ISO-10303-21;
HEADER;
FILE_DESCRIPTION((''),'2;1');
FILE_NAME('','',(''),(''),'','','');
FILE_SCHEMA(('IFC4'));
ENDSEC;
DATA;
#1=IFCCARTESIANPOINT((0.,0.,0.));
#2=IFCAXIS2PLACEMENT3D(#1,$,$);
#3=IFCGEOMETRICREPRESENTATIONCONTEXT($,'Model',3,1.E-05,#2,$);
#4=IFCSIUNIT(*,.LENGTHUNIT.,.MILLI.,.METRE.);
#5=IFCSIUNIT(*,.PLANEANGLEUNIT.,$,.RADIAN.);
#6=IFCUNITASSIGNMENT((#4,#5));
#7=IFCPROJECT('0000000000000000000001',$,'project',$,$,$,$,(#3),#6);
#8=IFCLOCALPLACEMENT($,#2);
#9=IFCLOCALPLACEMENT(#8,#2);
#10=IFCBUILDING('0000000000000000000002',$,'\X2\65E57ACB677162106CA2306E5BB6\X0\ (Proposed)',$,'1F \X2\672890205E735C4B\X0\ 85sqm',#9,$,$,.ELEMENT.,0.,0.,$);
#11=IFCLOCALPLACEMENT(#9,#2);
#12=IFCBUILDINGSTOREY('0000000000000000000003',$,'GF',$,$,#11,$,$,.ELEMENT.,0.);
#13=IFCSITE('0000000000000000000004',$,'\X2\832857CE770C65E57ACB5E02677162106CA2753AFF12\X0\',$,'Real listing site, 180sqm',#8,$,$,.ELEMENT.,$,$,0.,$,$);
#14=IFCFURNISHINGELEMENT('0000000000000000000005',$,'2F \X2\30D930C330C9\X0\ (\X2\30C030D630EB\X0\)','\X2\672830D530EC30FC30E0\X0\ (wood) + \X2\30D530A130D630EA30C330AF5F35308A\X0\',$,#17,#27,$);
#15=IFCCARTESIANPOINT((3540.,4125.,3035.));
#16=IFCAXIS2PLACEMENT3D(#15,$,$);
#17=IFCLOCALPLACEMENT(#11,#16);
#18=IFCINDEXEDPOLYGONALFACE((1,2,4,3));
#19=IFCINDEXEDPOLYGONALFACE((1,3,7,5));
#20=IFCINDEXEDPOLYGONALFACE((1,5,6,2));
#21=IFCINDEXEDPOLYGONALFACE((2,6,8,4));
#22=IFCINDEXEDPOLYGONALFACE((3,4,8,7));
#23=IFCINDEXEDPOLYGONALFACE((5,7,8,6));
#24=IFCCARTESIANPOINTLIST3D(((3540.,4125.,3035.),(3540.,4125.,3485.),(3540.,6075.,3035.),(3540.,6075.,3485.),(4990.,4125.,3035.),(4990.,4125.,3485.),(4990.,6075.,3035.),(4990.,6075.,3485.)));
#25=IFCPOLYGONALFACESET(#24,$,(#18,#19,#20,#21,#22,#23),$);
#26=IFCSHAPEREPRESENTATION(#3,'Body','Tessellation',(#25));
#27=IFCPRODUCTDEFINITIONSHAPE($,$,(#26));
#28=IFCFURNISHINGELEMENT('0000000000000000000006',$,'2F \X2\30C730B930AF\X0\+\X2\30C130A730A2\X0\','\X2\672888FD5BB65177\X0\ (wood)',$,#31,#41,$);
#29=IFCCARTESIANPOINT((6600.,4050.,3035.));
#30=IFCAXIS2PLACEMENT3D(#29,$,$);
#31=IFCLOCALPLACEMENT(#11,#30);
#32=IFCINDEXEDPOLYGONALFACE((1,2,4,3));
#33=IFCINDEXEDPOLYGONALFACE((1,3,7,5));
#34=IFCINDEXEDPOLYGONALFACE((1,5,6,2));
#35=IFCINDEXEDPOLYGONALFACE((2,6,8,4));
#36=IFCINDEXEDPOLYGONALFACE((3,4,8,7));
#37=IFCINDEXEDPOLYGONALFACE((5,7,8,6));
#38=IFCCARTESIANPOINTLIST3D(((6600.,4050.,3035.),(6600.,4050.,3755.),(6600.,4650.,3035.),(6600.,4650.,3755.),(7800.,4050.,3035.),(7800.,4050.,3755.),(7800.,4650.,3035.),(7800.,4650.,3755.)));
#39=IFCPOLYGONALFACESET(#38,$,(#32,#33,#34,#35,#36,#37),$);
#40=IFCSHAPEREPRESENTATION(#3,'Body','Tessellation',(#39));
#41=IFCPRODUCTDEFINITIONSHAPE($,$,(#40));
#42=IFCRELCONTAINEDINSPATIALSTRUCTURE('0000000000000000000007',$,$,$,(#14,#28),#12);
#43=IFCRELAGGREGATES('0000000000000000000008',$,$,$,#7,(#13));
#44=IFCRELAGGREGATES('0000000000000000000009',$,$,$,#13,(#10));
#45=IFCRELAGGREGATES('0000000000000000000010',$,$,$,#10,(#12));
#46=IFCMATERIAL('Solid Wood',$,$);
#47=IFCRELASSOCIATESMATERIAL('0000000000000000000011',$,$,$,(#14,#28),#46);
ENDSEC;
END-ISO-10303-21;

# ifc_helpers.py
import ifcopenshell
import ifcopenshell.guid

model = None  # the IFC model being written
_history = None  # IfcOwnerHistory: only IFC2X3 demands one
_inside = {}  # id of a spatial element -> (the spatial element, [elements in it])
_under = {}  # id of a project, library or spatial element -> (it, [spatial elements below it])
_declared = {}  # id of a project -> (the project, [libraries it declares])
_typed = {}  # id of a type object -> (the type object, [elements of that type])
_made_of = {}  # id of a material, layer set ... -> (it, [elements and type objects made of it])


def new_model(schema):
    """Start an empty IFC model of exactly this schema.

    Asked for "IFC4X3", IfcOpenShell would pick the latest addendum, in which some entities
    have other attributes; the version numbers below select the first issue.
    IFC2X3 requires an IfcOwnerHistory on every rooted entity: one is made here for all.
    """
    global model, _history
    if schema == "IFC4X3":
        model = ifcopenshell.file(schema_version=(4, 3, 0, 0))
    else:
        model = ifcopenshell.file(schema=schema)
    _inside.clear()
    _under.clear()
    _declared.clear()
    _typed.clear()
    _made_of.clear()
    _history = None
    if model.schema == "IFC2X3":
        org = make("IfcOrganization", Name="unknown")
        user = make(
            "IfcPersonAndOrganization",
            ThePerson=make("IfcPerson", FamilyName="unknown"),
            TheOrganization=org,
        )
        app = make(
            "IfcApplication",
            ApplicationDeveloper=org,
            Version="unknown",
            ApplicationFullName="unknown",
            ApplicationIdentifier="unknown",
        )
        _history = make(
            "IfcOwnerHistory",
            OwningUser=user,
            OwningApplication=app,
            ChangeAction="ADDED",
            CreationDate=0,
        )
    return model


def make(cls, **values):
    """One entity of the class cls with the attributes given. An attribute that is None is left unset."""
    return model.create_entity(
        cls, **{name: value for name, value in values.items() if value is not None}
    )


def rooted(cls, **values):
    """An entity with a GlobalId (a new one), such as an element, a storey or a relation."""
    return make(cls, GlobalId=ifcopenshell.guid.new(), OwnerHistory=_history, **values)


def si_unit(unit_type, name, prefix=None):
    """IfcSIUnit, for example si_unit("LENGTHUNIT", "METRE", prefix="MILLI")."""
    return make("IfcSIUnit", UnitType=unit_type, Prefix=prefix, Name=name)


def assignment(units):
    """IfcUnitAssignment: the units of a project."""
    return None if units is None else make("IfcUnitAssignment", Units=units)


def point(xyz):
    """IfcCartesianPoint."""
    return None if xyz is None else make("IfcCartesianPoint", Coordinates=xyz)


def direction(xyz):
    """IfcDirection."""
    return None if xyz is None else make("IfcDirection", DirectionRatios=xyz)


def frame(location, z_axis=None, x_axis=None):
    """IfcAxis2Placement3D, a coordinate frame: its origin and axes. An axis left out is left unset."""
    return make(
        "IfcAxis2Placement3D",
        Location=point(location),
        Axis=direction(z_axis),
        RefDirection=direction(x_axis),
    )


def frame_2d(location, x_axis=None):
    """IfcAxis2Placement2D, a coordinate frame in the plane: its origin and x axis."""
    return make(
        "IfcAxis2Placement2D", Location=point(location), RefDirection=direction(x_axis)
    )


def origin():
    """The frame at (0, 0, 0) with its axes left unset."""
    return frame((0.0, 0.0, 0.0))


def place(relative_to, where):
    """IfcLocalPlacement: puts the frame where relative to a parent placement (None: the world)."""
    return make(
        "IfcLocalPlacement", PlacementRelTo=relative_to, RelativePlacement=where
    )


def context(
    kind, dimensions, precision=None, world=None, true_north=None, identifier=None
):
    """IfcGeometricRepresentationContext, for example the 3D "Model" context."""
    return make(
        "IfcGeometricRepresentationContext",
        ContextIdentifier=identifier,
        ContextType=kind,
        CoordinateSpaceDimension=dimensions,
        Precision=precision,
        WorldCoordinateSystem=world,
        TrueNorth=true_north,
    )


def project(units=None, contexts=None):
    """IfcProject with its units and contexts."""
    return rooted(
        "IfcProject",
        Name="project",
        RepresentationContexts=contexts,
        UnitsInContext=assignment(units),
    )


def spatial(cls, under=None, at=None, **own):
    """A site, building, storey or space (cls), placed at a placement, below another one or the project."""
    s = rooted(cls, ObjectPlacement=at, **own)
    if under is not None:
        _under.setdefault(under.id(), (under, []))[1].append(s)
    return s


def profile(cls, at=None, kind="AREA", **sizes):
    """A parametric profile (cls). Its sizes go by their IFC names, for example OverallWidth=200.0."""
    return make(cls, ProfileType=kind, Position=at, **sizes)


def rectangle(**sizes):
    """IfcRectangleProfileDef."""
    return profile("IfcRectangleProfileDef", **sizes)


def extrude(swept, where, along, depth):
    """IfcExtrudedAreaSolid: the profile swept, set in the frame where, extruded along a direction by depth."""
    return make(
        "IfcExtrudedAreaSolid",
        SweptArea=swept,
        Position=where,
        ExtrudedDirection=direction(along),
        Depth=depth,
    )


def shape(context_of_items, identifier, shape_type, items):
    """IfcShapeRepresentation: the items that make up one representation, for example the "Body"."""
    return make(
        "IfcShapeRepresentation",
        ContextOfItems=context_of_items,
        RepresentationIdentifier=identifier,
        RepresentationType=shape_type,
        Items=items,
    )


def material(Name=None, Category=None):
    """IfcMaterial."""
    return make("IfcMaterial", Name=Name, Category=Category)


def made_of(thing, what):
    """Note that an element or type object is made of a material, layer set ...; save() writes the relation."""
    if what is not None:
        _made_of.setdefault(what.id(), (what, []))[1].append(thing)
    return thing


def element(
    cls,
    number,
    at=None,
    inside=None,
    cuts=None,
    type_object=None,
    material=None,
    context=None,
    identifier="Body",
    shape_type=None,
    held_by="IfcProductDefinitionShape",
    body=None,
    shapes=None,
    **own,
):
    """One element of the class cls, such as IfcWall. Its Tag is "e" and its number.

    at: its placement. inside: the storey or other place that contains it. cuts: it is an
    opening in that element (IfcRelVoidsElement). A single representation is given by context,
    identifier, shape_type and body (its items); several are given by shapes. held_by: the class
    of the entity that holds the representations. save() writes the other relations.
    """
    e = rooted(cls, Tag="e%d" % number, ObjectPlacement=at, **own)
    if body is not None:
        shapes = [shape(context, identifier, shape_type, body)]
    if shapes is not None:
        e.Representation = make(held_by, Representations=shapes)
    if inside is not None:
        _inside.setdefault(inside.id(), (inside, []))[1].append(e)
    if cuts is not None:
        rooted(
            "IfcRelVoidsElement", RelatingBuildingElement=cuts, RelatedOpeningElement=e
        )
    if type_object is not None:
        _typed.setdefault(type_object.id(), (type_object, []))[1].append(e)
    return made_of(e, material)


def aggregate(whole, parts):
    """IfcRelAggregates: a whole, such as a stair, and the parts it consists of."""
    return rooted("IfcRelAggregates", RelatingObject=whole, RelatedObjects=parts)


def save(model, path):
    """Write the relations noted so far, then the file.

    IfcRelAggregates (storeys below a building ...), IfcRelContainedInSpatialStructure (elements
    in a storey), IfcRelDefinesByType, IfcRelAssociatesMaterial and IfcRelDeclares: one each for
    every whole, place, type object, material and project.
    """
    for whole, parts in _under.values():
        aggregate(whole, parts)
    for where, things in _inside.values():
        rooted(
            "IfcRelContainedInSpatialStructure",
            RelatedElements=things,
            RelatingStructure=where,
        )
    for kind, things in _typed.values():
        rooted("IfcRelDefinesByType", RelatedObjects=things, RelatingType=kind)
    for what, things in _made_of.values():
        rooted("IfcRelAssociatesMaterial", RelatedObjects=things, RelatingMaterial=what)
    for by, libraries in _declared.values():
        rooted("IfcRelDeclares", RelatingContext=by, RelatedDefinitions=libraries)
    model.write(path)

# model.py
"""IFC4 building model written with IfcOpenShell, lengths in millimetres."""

from ifc_helpers import new_model, si_unit, frame, frame_2d, origin, place, context, project, spatial, rectangle, extrude, material, element, save


model = new_model("IFC4")

# Units and contexts
model_context = context("Model", 3, precision=1e-05, world=origin())
ifc_project = project(units=[si_unit("LENGTHUNIT", "METRE", prefix="MILLI"), si_unit("PLANEANGLEUNIT", "RADIAN")], contexts=[model_context])

# Site, building, storey
site_placement = place(None, origin())
site = spatial("IfcSite", under=ifc_project, at=site_placement, Name="茨城県日立市東成沢町２", ObjectType="Real listing site, 180sqm", CompositionType="ELEMENT", RefElevation=0.0)
building_placement = place(site_placement, origin())
building = spatial("IfcBuilding", under=site, at=building_placement, Name="日立東成沢の家 (Proposed)", ObjectType="1F 木造平屋 85sqm", CompositionType="ELEMENT", ElevationOfRefHeight=0.0, ElevationOfTerrain=0.0)
storey_placement = place(building_placement, origin())
storey = spatial("IfcBuildingStorey", under=building, at=storey_placement, Name="GF", CompositionType="ELEMENT", Elevation=0.0)

# Shared definitions
ifc_material_1 = material(Name="Solid Wood")

# Furnishing elements
furnishing_1_placement = place(storey_placement, frame((3540.0, 4125.0, 3035.0)))
element("IfcFurnishingElement", 1, at=furnishing_1_placement, inside=storey, material=ifc_material_1, Name="2F ベッド (ダブル)", Description="木フレーム (wood) + ファブリック張り", context=model_context, shape_type="SweptSolid", body=[
    extrude(rectangle(XDim=1450.0, YDim=1950.0, at=frame_2d((725.0, 975.0))), frame((3540.0, 4125.0, 3035.0)), (0.0, 0.0, 1.0), 450.0),
])
furnishing_2_placement = place(storey_placement, frame((6600.0, 4050.0, 3035.0)))
element("IfcFurnishingElement", 2, at=furnishing_2_placement, inside=storey, material=ifc_material_1, Name="2F デスク+チェア", Description="木製家具 (wood)", context=model_context, shape_type="SweptSolid", body=[
    extrude(rectangle(XDim=1200.0, YDim=600.0, at=frame_2d((600.0, 300.0))), frame((6600.0, 4050.0, 3035.0)), (0.0, 0.0, 1.0), 720.0),
])

save(model, "model.ifc")
